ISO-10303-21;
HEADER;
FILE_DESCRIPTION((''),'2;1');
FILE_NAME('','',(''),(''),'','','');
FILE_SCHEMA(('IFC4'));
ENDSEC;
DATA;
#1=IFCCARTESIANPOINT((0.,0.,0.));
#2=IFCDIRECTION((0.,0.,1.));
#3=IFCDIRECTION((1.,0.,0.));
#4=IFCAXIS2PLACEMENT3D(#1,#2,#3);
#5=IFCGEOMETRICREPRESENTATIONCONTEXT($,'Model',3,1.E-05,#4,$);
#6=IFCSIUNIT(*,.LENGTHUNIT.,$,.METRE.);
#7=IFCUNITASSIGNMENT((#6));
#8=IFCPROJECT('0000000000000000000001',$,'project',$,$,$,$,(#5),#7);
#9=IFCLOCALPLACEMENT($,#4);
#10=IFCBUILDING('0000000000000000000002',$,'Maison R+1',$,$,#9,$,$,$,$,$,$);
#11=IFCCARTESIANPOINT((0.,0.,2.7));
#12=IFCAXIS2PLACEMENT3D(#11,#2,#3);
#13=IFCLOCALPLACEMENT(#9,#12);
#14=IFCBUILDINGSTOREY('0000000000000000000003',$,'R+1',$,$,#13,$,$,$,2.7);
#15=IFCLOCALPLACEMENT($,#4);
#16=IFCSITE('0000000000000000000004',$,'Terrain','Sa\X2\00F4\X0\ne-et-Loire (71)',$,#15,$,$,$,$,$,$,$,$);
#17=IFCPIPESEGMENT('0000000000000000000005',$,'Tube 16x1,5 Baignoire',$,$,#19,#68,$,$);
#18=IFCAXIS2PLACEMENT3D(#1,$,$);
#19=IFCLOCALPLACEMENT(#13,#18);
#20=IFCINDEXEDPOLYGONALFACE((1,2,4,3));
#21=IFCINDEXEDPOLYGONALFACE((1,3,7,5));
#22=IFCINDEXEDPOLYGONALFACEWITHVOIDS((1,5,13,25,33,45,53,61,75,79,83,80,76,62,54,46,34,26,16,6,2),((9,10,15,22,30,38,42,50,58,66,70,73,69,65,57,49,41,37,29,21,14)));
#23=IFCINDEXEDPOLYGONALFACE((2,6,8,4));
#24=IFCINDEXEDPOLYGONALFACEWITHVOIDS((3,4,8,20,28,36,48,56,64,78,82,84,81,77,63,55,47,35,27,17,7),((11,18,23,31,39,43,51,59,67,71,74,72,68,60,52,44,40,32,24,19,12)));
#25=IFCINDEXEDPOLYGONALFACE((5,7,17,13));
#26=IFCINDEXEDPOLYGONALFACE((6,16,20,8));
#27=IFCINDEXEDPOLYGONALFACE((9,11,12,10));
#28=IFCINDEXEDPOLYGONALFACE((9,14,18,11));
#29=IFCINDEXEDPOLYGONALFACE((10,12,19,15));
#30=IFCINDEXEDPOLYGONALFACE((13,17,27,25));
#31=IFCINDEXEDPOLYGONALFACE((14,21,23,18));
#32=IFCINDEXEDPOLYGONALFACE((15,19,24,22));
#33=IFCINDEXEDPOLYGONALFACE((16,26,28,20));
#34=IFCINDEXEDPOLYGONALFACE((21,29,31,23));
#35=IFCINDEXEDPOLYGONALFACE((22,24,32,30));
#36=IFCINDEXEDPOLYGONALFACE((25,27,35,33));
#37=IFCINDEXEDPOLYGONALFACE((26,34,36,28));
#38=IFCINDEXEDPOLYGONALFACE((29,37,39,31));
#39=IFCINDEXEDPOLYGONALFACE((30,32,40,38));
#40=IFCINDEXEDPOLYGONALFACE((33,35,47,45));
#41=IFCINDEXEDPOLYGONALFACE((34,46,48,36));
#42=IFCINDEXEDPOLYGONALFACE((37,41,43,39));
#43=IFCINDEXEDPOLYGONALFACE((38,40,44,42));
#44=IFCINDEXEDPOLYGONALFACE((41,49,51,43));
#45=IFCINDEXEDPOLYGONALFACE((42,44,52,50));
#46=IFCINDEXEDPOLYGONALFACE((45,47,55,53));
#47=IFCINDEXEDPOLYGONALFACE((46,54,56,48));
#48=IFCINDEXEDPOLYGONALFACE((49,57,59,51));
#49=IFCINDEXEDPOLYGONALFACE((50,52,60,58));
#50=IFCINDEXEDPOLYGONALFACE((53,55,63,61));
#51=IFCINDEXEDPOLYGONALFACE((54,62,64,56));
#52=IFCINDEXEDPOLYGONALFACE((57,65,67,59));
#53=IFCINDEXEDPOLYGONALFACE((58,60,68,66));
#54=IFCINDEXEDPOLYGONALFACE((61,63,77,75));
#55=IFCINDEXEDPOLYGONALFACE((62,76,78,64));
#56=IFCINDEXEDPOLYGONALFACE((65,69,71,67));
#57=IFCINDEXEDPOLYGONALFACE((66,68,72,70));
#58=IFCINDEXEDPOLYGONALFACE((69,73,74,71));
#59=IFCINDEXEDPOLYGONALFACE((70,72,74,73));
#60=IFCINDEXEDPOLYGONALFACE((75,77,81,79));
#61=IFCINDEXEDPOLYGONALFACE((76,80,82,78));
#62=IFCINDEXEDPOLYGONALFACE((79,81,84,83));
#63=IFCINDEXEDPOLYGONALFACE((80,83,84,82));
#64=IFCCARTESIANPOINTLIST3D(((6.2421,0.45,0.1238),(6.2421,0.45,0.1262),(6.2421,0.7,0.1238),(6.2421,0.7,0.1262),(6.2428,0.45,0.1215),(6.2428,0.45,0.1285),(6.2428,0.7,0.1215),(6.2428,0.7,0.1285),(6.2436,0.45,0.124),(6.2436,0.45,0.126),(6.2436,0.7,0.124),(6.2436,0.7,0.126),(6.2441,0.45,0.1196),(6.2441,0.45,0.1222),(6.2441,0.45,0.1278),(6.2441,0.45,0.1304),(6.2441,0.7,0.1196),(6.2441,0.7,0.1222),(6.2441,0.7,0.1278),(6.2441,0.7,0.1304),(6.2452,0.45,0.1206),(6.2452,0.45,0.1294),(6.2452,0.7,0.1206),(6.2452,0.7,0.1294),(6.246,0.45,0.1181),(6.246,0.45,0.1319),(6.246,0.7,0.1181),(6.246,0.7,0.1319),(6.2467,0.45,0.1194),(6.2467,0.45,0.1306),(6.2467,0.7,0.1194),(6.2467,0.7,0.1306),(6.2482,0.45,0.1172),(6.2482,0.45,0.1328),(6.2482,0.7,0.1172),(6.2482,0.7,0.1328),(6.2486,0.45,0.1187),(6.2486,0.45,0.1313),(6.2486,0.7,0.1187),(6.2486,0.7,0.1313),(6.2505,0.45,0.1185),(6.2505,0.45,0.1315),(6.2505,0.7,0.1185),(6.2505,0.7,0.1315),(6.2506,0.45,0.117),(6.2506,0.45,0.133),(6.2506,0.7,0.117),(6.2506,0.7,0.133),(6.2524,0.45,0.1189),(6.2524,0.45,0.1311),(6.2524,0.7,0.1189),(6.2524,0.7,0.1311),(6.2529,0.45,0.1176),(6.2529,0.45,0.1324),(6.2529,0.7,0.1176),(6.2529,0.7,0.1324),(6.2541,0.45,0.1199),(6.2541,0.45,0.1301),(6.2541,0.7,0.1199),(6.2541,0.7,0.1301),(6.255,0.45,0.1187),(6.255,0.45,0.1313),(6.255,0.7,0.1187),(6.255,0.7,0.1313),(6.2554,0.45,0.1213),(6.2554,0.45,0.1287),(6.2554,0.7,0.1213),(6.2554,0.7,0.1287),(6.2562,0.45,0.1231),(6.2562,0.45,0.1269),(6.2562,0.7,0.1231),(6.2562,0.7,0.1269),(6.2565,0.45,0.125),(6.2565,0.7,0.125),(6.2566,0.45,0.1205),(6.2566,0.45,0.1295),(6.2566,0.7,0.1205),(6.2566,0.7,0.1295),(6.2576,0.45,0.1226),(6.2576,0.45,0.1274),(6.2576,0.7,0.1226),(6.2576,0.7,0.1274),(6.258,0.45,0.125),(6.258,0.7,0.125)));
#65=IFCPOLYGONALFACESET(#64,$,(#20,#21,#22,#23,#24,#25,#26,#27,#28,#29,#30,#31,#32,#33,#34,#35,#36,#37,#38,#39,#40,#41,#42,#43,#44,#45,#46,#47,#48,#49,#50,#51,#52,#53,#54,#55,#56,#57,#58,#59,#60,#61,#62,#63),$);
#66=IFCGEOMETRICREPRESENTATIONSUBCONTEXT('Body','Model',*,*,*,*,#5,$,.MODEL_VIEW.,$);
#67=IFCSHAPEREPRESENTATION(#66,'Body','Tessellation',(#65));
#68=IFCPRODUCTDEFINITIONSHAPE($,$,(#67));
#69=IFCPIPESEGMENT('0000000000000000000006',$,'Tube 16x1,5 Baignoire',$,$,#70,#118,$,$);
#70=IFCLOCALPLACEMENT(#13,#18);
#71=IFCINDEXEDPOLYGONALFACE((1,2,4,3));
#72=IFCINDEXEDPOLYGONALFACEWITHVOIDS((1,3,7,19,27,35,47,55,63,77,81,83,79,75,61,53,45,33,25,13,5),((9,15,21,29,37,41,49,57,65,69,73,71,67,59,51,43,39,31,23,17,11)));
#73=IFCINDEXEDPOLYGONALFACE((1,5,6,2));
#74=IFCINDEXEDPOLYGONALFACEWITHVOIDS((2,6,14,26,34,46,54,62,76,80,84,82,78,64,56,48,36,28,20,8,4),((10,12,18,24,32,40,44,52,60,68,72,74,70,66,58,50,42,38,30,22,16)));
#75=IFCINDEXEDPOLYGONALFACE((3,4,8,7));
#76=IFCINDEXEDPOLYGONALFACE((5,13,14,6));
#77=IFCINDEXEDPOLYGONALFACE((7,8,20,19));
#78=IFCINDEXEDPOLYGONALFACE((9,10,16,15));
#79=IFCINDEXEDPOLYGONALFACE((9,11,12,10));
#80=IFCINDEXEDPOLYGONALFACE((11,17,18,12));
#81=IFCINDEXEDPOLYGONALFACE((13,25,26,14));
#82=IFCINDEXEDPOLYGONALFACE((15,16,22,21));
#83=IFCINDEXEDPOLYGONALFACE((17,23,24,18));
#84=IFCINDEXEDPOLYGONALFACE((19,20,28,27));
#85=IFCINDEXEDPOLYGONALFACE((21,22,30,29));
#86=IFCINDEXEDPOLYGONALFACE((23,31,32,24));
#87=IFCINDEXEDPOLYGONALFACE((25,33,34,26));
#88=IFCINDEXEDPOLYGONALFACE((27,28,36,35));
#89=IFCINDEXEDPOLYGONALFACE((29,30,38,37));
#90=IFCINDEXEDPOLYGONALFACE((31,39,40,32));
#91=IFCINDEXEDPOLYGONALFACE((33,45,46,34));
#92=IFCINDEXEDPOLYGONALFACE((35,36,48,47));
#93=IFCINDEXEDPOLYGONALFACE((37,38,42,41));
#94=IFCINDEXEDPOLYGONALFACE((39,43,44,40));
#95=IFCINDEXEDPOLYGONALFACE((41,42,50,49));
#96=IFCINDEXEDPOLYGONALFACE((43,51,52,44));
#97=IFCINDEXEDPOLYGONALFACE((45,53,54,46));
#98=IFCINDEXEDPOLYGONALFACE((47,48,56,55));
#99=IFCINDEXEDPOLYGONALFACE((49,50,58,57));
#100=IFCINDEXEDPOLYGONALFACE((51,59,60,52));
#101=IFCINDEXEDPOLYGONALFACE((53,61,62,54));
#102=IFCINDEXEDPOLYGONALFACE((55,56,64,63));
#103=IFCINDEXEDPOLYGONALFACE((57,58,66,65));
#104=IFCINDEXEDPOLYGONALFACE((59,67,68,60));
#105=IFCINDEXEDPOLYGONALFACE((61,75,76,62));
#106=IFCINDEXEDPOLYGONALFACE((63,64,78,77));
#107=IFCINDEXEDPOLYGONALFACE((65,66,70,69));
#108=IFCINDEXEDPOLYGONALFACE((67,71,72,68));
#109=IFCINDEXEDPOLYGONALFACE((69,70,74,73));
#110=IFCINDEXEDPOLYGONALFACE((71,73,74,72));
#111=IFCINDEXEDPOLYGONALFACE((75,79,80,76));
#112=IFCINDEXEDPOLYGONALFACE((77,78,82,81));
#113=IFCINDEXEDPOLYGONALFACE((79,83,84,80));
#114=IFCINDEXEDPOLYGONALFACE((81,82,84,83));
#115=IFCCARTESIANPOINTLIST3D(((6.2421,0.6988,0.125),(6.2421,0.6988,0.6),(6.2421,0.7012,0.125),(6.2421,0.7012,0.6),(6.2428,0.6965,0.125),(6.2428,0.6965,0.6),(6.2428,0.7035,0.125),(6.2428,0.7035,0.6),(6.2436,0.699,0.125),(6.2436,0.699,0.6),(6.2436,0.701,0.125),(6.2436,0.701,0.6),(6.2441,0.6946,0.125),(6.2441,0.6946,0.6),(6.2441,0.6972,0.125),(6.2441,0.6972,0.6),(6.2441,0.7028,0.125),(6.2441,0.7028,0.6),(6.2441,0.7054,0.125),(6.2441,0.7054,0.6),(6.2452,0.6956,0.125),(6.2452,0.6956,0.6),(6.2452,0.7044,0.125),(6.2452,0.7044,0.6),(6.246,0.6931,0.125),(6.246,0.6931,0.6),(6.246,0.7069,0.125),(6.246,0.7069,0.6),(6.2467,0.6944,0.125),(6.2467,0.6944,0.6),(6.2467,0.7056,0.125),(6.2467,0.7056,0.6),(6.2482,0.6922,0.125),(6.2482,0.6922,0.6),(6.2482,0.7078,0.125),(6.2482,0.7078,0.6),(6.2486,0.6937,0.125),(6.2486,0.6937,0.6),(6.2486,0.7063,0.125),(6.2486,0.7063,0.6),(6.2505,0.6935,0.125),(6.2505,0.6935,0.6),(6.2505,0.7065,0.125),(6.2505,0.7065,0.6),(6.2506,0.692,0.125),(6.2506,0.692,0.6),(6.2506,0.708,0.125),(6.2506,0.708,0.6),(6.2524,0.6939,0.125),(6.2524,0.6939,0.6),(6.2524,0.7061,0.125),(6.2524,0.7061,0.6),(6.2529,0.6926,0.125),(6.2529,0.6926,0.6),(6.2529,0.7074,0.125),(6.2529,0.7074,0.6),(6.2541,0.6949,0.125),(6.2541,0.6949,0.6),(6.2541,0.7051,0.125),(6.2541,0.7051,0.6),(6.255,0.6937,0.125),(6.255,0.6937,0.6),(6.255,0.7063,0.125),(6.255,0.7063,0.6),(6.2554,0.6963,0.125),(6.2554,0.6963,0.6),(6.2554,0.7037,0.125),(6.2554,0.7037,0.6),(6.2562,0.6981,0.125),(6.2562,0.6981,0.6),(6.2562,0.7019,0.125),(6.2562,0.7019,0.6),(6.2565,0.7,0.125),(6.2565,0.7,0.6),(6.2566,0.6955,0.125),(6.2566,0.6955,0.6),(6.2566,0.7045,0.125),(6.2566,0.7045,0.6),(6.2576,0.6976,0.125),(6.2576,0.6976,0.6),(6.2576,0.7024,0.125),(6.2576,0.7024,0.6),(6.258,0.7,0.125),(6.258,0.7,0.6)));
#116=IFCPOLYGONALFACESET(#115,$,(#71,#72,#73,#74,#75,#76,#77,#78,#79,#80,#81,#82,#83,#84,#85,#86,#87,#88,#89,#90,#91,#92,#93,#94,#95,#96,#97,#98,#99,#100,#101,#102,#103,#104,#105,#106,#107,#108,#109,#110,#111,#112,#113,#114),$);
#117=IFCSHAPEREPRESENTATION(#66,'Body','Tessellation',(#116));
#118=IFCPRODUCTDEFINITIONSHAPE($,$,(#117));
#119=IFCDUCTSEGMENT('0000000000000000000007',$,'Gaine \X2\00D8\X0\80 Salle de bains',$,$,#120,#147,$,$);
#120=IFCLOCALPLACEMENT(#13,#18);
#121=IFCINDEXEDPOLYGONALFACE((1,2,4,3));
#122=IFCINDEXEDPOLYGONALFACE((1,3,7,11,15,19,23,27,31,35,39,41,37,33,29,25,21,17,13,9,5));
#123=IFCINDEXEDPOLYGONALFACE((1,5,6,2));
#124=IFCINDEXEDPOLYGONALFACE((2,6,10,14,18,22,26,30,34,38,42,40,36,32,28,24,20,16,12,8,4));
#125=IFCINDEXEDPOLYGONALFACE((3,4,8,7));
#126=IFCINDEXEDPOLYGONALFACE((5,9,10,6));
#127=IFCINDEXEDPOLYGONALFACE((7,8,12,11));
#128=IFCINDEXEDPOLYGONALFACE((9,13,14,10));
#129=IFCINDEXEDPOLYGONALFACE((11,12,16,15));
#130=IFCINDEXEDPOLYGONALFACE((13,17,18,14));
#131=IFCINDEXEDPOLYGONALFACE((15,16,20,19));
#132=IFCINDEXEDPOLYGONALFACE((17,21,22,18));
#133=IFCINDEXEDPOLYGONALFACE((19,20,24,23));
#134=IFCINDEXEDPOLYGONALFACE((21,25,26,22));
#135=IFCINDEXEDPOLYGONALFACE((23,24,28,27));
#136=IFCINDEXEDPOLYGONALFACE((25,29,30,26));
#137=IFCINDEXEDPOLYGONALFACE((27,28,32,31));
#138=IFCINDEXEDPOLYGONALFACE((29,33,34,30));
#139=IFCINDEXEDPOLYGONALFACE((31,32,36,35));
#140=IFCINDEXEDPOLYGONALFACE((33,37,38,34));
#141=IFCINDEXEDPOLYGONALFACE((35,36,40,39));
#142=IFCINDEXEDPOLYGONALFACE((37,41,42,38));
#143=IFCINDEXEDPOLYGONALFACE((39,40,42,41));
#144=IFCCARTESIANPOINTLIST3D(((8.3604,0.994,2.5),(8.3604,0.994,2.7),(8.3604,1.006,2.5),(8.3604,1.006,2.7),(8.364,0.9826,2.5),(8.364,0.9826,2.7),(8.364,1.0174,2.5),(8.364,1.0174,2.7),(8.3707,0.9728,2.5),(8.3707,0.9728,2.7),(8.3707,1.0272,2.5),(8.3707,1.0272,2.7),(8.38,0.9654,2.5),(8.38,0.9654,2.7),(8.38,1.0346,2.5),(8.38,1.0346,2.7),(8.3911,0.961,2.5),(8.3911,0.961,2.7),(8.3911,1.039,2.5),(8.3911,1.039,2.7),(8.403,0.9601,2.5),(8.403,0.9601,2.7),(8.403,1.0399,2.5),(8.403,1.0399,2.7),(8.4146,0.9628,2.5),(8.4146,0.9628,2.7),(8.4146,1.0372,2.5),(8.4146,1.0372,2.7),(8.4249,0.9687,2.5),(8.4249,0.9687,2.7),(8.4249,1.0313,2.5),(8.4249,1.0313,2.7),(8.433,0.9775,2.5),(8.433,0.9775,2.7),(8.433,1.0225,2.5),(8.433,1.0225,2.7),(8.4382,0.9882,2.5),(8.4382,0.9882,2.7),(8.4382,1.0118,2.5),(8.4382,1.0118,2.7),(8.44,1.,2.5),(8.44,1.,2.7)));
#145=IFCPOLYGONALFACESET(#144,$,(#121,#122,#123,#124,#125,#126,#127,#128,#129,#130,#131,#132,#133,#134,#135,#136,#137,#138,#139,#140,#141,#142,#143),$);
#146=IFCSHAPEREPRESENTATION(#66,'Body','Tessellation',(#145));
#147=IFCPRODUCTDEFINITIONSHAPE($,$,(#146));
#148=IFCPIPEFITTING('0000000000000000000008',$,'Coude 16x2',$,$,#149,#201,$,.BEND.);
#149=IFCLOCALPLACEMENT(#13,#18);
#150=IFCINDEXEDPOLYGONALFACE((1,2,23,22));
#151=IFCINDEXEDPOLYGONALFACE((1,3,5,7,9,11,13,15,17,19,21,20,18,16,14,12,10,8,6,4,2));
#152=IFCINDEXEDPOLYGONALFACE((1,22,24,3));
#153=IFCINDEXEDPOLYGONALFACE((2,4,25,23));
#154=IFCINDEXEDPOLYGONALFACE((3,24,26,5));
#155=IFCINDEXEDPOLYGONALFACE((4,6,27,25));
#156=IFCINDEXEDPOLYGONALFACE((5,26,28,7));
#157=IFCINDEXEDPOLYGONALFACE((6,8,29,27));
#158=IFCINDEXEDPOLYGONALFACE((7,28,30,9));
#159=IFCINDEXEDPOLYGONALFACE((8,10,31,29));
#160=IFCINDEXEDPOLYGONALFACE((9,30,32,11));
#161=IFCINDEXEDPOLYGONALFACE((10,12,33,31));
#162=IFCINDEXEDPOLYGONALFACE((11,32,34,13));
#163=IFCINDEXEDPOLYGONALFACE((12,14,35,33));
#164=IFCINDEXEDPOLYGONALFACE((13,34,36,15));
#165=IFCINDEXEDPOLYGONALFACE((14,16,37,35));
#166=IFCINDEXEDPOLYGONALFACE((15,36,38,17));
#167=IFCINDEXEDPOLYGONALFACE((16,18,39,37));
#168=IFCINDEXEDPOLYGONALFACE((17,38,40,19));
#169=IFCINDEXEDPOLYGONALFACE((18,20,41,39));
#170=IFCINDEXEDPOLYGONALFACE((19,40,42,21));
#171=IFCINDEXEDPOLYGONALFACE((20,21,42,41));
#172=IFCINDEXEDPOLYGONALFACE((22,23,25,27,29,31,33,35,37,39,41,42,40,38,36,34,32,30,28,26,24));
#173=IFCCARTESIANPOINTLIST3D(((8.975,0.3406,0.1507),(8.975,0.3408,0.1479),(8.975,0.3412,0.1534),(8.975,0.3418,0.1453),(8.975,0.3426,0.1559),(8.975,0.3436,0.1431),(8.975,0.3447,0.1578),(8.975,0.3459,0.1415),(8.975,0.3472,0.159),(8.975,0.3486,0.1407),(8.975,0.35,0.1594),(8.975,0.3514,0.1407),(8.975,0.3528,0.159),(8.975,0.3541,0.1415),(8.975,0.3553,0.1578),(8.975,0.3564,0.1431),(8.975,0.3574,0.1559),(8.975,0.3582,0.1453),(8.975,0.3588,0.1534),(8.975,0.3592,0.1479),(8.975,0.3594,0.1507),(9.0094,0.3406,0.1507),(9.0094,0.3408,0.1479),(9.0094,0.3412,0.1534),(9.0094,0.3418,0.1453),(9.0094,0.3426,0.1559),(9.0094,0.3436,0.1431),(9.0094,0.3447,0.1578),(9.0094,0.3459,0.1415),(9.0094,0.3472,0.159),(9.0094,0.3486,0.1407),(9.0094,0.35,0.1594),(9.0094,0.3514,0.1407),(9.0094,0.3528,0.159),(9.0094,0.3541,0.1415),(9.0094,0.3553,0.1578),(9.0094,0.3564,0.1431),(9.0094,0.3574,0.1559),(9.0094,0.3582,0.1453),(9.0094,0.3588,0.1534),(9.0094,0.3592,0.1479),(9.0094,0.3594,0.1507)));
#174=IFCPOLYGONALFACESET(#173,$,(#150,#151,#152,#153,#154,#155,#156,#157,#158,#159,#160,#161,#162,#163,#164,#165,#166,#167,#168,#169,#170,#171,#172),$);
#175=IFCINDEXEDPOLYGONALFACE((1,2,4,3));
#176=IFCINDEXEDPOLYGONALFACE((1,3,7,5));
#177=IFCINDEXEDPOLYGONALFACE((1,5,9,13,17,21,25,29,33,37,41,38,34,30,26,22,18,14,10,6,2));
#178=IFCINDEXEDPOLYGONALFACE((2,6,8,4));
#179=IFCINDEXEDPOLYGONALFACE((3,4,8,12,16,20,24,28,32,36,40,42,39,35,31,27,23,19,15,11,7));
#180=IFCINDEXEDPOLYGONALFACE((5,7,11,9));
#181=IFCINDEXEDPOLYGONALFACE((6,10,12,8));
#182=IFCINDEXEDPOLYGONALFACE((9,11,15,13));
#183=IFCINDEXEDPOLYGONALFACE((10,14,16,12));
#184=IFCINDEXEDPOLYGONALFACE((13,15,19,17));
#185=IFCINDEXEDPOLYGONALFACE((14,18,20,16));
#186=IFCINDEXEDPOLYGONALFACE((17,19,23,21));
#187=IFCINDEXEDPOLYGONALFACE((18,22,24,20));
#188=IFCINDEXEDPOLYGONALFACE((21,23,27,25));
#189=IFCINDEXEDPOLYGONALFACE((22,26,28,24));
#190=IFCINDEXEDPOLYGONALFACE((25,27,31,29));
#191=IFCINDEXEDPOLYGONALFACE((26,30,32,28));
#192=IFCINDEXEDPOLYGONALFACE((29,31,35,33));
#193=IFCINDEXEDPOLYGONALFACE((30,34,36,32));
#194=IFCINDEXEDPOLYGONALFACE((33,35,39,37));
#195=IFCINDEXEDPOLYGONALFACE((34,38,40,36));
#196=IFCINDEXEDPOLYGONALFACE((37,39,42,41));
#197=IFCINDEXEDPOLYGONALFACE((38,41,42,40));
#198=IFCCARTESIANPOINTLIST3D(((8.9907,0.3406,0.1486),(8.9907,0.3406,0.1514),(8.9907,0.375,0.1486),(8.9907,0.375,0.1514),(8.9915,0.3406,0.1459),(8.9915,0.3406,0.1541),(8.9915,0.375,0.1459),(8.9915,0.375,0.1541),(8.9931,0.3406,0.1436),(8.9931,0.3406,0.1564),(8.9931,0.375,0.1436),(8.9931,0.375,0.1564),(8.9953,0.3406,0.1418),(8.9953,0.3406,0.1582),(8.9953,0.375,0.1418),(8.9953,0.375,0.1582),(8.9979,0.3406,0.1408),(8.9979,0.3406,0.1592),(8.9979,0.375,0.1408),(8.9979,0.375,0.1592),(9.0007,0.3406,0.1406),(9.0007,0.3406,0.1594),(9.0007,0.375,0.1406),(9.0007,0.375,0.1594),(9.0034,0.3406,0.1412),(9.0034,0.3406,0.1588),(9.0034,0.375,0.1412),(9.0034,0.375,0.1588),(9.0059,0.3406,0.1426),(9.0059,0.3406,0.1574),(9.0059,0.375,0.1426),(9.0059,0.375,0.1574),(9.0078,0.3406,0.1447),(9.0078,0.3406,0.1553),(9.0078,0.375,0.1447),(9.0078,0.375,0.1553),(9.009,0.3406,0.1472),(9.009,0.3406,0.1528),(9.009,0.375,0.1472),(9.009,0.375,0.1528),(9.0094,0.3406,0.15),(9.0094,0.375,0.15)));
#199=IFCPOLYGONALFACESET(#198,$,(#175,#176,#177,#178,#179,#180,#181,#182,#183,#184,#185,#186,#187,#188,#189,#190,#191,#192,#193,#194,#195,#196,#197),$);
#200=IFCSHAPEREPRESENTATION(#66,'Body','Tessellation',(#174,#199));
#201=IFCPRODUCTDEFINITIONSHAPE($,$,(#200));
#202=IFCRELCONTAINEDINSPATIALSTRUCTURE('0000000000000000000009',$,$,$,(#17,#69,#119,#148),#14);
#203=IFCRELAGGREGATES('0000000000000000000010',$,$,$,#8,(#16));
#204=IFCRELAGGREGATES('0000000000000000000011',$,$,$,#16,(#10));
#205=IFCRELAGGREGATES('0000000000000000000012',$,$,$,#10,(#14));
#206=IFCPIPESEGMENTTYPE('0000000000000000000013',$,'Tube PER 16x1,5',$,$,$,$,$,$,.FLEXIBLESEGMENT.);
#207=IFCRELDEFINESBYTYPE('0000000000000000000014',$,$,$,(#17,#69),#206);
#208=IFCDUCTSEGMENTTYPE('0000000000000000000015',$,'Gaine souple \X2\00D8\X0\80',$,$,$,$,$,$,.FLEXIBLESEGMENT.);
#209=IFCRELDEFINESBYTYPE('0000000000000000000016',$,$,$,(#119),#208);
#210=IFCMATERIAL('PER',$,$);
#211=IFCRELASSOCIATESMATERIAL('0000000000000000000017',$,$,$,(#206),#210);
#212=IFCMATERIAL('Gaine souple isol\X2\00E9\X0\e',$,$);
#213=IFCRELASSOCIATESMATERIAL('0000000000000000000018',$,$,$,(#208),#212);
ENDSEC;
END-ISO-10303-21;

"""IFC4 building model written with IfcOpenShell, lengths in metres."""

from ifc_helpers import new_model, si_unit, frame, origin_with_axes, place, context, subcontext, project, spatial, circle, hollow_circle, extrude, material, type_object, element, save


model = new_model("IFC4")

# Units and contexts
model_context = context("Model", 3, precision=1e-05, world=origin_with_axes())
body_context = subcontext(model_context, "Body", "Model", "MODEL_VIEW")
ifc_project = project(units=[si_unit("LENGTHUNIT", "METRE")], contexts=[model_context])

# Site, building, storey
site_placement = place(None, origin_with_axes())
site = spatial("IfcSite", under=ifc_project, at=site_placement, Name="Terrain", Description="Saône-et-Loire (71)")
building_placement = place(None, origin_with_axes())
building = spatial("IfcBuilding", under=site, at=building_placement, Name="Maison R+1")
storey_placement = place(building_placement, frame((0.0, 0.0, 2.7), z_axis=(0.0, 0.0, 1.0), x_axis=(1.0, 0.0, 0.0)))
storey = spatial("IfcBuildingStorey", under=building, at=storey_placement, Name="R+1", Elevation=2.7)

# Pipe segments
ifc_material_1 = material(Name="PER")
pipe_segment_type_1 = type_object("IfcPipeSegmentType", Name="Tube PER 16x1,5", PredefinedType="FLEXIBLESEGMENT", material=ifc_material_1)
pipe_segment_1_placement = place(storey_placement, frame((6.25, 0.45, 0.125), z_axis=(0.0, 1.0, 0.0), x_axis=(1.0, 0.0, 0.0)))
element("IfcPipeSegment", 1, at=pipe_segment_1_placement, inside=storey, type_object=pipe_segment_type_1, Name="Tube 16x1,5 Baignoire", context=body_context, shape_type="SweptSolid", body=[
    extrude(hollow_circle(Radius=0.008, WallThickness=0.0015), origin_with_axes(), (0.0, 0.0, 1.0), 0.25),
])
pipe_segment_2_placement = place(storey_placement, frame((6.25, 0.7, 0.125), z_axis=(0.0, 0.0, 1.0), x_axis=(1.0, 0.0, 0.0)))
element("IfcPipeSegment", 2, at=pipe_segment_2_placement, inside=storey, type_object=pipe_segment_type_1, Name="Tube 16x1,5 Baignoire", context=body_context, shape_type="SweptSolid", body=[
    extrude(hollow_circle(Radius=0.008, WallThickness=0.0015), origin_with_axes(), (0.0, 0.0, 1.0), 0.475),
])

# Duct segment
ifc_material_2 = material(Name="Gaine souple isolée")
duct_segment_type = type_object("IfcDuctSegmentType", Name="Gaine souple Ø80", PredefinedType="FLEXIBLESEGMENT", material=ifc_material_2)
duct_segment_placement = place(storey_placement, frame((8.4, 1.0, 2.5), z_axis=(0.0, 0.0, 1.0), x_axis=(1.0, 0.0, 0.0)))
element("IfcDuctSegment", 3, at=duct_segment_placement, inside=storey, type_object=duct_segment_type, Name="Gaine Ø80 Salle de bains", context=body_context, shape_type="SweptSolid", body=[
    extrude(circle(Radius=0.04), origin_with_axes(), (0.0, 0.0, 1.0), 0.2),
])

# Pipe fitting
pipe_fitting_1_placement = place(storey_placement, frame((9.0, 0.35, 0.15), z_axis=(0.0, 0.0, 1.0), x_axis=(1.0, 0.0, 0.0)))
element("IfcPipeFitting", 4, at=pipe_fitting_1_placement, inside=storey, Name="Coude 16x2", PredefinedType="BEND", context=body_context, shape_type="SweptSolid", body=[
    extrude(circle(Radius=0.0094), frame((0.0094, 0.0, 0.0), z_axis=(-1.0, 0.0, 0.0), x_axis=(0.0, 0.0, 1.0)), (0.0, 0.0, 1.0), 0.0344),
    extrude(circle(Radius=0.0094), frame((0.0, -0.0094, 0.0), z_axis=(0.0, 1.0, 0.0), x_axis=(1.0, 0.0, 0.0)), (0.0, 0.0, 1.0), 0.0344),
])

save(model, "model.ifc")
